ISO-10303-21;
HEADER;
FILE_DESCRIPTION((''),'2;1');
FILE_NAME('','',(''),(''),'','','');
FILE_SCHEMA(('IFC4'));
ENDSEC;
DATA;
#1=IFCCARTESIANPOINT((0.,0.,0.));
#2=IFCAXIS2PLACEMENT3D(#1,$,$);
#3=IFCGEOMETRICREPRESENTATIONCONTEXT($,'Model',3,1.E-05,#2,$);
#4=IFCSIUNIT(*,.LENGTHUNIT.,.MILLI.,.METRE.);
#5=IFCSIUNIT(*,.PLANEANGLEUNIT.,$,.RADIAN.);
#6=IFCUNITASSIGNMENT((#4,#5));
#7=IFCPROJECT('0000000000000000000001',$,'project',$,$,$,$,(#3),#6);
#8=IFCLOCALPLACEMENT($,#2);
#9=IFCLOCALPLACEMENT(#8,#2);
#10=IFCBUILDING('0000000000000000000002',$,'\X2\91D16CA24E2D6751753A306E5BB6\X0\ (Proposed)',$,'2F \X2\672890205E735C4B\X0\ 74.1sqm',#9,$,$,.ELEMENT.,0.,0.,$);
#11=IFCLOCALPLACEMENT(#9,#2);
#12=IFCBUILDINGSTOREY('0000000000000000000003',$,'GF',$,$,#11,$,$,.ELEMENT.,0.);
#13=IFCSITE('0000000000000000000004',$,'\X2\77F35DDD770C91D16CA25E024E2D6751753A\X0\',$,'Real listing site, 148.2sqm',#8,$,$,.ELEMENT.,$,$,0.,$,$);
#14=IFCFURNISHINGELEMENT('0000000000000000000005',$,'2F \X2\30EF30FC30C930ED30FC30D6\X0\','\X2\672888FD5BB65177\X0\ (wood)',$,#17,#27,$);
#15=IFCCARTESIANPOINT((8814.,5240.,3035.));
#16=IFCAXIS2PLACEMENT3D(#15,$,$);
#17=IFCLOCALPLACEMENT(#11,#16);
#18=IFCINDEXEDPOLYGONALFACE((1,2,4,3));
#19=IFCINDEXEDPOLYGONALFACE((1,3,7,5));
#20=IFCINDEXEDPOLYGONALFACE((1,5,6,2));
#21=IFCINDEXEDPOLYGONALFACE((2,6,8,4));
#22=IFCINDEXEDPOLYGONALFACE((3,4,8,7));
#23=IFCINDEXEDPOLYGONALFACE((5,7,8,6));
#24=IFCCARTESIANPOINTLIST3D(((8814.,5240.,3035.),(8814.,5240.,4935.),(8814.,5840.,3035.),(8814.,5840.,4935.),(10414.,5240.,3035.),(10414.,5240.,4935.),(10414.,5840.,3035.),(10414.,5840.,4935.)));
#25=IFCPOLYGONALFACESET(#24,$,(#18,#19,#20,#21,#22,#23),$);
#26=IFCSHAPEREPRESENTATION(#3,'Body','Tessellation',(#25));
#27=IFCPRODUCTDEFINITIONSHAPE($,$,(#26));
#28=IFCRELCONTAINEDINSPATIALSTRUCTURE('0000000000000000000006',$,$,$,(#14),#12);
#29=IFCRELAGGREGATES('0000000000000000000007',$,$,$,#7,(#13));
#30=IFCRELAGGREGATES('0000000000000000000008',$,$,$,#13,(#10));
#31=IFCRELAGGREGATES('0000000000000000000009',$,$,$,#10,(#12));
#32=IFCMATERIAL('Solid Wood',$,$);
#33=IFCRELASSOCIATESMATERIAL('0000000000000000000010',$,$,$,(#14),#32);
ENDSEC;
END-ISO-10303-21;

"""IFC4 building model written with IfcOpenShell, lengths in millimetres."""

from ifc_helpers import new_model, si_unit, frame, frame_2d, origin, place, context, project, spatial, rectangle, extrude, material, element, save


model = new_model("IFC4")

# Units and contexts
model_context = context("Model", 3, precision=1e-05, world=origin())
ifc_project = project(units=[si_unit("LENGTHUNIT", "METRE", prefix="MILLI"), si_unit("PLANEANGLEUNIT", "RADIAN")], contexts=[model_context])

# Site, building, storey
site_placement = place(None, origin())
site = spatial("IfcSite", under=ifc_project, at=site_placement, Name="石川県金沢市中村町", ObjectType="Real listing site, 148.2sqm", CompositionType="ELEMENT", RefElevation=0.0)
building_placement = place(site_placement, origin())
building = spatial("IfcBuilding", under=site, at=building_placement, Name="金沢中村町の家 (Proposed)", ObjectType="2F 木造平屋 74.1sqm", CompositionType="ELEMENT", ElevationOfRefHeight=0.0, ElevationOfTerrain=0.0)
storey_placement = place(building_placement, origin())
storey = spatial("IfcBuildingStorey", under=building, at=storey_placement, Name="GF", CompositionType="ELEMENT", Elevation=0.0)

# Shared definitions
ifc_material_1 = material(Name="Solid Wood")

# Furnishing element
furnishing_1_placement = place(storey_placement, frame((8814.0, 5240.0, 3035.0)))
element("IfcFurnishingElement", 1, at=furnishing_1_placement, inside=storey, material=ifc_material_1, Name="2F ワードローブ", Description="木製家具 (wood)", context=model_context, shape_type="SweptSolid", body=[
    extrude(rectangle(XDim=1600.0, YDim=600.0, at=frame_2d((800.0, 300.0))), frame((8814.0, 5240.0, 3035.0)), (0.0, 0.0, 1.0), 1900.0),
])

save(model, "model.ifc")
